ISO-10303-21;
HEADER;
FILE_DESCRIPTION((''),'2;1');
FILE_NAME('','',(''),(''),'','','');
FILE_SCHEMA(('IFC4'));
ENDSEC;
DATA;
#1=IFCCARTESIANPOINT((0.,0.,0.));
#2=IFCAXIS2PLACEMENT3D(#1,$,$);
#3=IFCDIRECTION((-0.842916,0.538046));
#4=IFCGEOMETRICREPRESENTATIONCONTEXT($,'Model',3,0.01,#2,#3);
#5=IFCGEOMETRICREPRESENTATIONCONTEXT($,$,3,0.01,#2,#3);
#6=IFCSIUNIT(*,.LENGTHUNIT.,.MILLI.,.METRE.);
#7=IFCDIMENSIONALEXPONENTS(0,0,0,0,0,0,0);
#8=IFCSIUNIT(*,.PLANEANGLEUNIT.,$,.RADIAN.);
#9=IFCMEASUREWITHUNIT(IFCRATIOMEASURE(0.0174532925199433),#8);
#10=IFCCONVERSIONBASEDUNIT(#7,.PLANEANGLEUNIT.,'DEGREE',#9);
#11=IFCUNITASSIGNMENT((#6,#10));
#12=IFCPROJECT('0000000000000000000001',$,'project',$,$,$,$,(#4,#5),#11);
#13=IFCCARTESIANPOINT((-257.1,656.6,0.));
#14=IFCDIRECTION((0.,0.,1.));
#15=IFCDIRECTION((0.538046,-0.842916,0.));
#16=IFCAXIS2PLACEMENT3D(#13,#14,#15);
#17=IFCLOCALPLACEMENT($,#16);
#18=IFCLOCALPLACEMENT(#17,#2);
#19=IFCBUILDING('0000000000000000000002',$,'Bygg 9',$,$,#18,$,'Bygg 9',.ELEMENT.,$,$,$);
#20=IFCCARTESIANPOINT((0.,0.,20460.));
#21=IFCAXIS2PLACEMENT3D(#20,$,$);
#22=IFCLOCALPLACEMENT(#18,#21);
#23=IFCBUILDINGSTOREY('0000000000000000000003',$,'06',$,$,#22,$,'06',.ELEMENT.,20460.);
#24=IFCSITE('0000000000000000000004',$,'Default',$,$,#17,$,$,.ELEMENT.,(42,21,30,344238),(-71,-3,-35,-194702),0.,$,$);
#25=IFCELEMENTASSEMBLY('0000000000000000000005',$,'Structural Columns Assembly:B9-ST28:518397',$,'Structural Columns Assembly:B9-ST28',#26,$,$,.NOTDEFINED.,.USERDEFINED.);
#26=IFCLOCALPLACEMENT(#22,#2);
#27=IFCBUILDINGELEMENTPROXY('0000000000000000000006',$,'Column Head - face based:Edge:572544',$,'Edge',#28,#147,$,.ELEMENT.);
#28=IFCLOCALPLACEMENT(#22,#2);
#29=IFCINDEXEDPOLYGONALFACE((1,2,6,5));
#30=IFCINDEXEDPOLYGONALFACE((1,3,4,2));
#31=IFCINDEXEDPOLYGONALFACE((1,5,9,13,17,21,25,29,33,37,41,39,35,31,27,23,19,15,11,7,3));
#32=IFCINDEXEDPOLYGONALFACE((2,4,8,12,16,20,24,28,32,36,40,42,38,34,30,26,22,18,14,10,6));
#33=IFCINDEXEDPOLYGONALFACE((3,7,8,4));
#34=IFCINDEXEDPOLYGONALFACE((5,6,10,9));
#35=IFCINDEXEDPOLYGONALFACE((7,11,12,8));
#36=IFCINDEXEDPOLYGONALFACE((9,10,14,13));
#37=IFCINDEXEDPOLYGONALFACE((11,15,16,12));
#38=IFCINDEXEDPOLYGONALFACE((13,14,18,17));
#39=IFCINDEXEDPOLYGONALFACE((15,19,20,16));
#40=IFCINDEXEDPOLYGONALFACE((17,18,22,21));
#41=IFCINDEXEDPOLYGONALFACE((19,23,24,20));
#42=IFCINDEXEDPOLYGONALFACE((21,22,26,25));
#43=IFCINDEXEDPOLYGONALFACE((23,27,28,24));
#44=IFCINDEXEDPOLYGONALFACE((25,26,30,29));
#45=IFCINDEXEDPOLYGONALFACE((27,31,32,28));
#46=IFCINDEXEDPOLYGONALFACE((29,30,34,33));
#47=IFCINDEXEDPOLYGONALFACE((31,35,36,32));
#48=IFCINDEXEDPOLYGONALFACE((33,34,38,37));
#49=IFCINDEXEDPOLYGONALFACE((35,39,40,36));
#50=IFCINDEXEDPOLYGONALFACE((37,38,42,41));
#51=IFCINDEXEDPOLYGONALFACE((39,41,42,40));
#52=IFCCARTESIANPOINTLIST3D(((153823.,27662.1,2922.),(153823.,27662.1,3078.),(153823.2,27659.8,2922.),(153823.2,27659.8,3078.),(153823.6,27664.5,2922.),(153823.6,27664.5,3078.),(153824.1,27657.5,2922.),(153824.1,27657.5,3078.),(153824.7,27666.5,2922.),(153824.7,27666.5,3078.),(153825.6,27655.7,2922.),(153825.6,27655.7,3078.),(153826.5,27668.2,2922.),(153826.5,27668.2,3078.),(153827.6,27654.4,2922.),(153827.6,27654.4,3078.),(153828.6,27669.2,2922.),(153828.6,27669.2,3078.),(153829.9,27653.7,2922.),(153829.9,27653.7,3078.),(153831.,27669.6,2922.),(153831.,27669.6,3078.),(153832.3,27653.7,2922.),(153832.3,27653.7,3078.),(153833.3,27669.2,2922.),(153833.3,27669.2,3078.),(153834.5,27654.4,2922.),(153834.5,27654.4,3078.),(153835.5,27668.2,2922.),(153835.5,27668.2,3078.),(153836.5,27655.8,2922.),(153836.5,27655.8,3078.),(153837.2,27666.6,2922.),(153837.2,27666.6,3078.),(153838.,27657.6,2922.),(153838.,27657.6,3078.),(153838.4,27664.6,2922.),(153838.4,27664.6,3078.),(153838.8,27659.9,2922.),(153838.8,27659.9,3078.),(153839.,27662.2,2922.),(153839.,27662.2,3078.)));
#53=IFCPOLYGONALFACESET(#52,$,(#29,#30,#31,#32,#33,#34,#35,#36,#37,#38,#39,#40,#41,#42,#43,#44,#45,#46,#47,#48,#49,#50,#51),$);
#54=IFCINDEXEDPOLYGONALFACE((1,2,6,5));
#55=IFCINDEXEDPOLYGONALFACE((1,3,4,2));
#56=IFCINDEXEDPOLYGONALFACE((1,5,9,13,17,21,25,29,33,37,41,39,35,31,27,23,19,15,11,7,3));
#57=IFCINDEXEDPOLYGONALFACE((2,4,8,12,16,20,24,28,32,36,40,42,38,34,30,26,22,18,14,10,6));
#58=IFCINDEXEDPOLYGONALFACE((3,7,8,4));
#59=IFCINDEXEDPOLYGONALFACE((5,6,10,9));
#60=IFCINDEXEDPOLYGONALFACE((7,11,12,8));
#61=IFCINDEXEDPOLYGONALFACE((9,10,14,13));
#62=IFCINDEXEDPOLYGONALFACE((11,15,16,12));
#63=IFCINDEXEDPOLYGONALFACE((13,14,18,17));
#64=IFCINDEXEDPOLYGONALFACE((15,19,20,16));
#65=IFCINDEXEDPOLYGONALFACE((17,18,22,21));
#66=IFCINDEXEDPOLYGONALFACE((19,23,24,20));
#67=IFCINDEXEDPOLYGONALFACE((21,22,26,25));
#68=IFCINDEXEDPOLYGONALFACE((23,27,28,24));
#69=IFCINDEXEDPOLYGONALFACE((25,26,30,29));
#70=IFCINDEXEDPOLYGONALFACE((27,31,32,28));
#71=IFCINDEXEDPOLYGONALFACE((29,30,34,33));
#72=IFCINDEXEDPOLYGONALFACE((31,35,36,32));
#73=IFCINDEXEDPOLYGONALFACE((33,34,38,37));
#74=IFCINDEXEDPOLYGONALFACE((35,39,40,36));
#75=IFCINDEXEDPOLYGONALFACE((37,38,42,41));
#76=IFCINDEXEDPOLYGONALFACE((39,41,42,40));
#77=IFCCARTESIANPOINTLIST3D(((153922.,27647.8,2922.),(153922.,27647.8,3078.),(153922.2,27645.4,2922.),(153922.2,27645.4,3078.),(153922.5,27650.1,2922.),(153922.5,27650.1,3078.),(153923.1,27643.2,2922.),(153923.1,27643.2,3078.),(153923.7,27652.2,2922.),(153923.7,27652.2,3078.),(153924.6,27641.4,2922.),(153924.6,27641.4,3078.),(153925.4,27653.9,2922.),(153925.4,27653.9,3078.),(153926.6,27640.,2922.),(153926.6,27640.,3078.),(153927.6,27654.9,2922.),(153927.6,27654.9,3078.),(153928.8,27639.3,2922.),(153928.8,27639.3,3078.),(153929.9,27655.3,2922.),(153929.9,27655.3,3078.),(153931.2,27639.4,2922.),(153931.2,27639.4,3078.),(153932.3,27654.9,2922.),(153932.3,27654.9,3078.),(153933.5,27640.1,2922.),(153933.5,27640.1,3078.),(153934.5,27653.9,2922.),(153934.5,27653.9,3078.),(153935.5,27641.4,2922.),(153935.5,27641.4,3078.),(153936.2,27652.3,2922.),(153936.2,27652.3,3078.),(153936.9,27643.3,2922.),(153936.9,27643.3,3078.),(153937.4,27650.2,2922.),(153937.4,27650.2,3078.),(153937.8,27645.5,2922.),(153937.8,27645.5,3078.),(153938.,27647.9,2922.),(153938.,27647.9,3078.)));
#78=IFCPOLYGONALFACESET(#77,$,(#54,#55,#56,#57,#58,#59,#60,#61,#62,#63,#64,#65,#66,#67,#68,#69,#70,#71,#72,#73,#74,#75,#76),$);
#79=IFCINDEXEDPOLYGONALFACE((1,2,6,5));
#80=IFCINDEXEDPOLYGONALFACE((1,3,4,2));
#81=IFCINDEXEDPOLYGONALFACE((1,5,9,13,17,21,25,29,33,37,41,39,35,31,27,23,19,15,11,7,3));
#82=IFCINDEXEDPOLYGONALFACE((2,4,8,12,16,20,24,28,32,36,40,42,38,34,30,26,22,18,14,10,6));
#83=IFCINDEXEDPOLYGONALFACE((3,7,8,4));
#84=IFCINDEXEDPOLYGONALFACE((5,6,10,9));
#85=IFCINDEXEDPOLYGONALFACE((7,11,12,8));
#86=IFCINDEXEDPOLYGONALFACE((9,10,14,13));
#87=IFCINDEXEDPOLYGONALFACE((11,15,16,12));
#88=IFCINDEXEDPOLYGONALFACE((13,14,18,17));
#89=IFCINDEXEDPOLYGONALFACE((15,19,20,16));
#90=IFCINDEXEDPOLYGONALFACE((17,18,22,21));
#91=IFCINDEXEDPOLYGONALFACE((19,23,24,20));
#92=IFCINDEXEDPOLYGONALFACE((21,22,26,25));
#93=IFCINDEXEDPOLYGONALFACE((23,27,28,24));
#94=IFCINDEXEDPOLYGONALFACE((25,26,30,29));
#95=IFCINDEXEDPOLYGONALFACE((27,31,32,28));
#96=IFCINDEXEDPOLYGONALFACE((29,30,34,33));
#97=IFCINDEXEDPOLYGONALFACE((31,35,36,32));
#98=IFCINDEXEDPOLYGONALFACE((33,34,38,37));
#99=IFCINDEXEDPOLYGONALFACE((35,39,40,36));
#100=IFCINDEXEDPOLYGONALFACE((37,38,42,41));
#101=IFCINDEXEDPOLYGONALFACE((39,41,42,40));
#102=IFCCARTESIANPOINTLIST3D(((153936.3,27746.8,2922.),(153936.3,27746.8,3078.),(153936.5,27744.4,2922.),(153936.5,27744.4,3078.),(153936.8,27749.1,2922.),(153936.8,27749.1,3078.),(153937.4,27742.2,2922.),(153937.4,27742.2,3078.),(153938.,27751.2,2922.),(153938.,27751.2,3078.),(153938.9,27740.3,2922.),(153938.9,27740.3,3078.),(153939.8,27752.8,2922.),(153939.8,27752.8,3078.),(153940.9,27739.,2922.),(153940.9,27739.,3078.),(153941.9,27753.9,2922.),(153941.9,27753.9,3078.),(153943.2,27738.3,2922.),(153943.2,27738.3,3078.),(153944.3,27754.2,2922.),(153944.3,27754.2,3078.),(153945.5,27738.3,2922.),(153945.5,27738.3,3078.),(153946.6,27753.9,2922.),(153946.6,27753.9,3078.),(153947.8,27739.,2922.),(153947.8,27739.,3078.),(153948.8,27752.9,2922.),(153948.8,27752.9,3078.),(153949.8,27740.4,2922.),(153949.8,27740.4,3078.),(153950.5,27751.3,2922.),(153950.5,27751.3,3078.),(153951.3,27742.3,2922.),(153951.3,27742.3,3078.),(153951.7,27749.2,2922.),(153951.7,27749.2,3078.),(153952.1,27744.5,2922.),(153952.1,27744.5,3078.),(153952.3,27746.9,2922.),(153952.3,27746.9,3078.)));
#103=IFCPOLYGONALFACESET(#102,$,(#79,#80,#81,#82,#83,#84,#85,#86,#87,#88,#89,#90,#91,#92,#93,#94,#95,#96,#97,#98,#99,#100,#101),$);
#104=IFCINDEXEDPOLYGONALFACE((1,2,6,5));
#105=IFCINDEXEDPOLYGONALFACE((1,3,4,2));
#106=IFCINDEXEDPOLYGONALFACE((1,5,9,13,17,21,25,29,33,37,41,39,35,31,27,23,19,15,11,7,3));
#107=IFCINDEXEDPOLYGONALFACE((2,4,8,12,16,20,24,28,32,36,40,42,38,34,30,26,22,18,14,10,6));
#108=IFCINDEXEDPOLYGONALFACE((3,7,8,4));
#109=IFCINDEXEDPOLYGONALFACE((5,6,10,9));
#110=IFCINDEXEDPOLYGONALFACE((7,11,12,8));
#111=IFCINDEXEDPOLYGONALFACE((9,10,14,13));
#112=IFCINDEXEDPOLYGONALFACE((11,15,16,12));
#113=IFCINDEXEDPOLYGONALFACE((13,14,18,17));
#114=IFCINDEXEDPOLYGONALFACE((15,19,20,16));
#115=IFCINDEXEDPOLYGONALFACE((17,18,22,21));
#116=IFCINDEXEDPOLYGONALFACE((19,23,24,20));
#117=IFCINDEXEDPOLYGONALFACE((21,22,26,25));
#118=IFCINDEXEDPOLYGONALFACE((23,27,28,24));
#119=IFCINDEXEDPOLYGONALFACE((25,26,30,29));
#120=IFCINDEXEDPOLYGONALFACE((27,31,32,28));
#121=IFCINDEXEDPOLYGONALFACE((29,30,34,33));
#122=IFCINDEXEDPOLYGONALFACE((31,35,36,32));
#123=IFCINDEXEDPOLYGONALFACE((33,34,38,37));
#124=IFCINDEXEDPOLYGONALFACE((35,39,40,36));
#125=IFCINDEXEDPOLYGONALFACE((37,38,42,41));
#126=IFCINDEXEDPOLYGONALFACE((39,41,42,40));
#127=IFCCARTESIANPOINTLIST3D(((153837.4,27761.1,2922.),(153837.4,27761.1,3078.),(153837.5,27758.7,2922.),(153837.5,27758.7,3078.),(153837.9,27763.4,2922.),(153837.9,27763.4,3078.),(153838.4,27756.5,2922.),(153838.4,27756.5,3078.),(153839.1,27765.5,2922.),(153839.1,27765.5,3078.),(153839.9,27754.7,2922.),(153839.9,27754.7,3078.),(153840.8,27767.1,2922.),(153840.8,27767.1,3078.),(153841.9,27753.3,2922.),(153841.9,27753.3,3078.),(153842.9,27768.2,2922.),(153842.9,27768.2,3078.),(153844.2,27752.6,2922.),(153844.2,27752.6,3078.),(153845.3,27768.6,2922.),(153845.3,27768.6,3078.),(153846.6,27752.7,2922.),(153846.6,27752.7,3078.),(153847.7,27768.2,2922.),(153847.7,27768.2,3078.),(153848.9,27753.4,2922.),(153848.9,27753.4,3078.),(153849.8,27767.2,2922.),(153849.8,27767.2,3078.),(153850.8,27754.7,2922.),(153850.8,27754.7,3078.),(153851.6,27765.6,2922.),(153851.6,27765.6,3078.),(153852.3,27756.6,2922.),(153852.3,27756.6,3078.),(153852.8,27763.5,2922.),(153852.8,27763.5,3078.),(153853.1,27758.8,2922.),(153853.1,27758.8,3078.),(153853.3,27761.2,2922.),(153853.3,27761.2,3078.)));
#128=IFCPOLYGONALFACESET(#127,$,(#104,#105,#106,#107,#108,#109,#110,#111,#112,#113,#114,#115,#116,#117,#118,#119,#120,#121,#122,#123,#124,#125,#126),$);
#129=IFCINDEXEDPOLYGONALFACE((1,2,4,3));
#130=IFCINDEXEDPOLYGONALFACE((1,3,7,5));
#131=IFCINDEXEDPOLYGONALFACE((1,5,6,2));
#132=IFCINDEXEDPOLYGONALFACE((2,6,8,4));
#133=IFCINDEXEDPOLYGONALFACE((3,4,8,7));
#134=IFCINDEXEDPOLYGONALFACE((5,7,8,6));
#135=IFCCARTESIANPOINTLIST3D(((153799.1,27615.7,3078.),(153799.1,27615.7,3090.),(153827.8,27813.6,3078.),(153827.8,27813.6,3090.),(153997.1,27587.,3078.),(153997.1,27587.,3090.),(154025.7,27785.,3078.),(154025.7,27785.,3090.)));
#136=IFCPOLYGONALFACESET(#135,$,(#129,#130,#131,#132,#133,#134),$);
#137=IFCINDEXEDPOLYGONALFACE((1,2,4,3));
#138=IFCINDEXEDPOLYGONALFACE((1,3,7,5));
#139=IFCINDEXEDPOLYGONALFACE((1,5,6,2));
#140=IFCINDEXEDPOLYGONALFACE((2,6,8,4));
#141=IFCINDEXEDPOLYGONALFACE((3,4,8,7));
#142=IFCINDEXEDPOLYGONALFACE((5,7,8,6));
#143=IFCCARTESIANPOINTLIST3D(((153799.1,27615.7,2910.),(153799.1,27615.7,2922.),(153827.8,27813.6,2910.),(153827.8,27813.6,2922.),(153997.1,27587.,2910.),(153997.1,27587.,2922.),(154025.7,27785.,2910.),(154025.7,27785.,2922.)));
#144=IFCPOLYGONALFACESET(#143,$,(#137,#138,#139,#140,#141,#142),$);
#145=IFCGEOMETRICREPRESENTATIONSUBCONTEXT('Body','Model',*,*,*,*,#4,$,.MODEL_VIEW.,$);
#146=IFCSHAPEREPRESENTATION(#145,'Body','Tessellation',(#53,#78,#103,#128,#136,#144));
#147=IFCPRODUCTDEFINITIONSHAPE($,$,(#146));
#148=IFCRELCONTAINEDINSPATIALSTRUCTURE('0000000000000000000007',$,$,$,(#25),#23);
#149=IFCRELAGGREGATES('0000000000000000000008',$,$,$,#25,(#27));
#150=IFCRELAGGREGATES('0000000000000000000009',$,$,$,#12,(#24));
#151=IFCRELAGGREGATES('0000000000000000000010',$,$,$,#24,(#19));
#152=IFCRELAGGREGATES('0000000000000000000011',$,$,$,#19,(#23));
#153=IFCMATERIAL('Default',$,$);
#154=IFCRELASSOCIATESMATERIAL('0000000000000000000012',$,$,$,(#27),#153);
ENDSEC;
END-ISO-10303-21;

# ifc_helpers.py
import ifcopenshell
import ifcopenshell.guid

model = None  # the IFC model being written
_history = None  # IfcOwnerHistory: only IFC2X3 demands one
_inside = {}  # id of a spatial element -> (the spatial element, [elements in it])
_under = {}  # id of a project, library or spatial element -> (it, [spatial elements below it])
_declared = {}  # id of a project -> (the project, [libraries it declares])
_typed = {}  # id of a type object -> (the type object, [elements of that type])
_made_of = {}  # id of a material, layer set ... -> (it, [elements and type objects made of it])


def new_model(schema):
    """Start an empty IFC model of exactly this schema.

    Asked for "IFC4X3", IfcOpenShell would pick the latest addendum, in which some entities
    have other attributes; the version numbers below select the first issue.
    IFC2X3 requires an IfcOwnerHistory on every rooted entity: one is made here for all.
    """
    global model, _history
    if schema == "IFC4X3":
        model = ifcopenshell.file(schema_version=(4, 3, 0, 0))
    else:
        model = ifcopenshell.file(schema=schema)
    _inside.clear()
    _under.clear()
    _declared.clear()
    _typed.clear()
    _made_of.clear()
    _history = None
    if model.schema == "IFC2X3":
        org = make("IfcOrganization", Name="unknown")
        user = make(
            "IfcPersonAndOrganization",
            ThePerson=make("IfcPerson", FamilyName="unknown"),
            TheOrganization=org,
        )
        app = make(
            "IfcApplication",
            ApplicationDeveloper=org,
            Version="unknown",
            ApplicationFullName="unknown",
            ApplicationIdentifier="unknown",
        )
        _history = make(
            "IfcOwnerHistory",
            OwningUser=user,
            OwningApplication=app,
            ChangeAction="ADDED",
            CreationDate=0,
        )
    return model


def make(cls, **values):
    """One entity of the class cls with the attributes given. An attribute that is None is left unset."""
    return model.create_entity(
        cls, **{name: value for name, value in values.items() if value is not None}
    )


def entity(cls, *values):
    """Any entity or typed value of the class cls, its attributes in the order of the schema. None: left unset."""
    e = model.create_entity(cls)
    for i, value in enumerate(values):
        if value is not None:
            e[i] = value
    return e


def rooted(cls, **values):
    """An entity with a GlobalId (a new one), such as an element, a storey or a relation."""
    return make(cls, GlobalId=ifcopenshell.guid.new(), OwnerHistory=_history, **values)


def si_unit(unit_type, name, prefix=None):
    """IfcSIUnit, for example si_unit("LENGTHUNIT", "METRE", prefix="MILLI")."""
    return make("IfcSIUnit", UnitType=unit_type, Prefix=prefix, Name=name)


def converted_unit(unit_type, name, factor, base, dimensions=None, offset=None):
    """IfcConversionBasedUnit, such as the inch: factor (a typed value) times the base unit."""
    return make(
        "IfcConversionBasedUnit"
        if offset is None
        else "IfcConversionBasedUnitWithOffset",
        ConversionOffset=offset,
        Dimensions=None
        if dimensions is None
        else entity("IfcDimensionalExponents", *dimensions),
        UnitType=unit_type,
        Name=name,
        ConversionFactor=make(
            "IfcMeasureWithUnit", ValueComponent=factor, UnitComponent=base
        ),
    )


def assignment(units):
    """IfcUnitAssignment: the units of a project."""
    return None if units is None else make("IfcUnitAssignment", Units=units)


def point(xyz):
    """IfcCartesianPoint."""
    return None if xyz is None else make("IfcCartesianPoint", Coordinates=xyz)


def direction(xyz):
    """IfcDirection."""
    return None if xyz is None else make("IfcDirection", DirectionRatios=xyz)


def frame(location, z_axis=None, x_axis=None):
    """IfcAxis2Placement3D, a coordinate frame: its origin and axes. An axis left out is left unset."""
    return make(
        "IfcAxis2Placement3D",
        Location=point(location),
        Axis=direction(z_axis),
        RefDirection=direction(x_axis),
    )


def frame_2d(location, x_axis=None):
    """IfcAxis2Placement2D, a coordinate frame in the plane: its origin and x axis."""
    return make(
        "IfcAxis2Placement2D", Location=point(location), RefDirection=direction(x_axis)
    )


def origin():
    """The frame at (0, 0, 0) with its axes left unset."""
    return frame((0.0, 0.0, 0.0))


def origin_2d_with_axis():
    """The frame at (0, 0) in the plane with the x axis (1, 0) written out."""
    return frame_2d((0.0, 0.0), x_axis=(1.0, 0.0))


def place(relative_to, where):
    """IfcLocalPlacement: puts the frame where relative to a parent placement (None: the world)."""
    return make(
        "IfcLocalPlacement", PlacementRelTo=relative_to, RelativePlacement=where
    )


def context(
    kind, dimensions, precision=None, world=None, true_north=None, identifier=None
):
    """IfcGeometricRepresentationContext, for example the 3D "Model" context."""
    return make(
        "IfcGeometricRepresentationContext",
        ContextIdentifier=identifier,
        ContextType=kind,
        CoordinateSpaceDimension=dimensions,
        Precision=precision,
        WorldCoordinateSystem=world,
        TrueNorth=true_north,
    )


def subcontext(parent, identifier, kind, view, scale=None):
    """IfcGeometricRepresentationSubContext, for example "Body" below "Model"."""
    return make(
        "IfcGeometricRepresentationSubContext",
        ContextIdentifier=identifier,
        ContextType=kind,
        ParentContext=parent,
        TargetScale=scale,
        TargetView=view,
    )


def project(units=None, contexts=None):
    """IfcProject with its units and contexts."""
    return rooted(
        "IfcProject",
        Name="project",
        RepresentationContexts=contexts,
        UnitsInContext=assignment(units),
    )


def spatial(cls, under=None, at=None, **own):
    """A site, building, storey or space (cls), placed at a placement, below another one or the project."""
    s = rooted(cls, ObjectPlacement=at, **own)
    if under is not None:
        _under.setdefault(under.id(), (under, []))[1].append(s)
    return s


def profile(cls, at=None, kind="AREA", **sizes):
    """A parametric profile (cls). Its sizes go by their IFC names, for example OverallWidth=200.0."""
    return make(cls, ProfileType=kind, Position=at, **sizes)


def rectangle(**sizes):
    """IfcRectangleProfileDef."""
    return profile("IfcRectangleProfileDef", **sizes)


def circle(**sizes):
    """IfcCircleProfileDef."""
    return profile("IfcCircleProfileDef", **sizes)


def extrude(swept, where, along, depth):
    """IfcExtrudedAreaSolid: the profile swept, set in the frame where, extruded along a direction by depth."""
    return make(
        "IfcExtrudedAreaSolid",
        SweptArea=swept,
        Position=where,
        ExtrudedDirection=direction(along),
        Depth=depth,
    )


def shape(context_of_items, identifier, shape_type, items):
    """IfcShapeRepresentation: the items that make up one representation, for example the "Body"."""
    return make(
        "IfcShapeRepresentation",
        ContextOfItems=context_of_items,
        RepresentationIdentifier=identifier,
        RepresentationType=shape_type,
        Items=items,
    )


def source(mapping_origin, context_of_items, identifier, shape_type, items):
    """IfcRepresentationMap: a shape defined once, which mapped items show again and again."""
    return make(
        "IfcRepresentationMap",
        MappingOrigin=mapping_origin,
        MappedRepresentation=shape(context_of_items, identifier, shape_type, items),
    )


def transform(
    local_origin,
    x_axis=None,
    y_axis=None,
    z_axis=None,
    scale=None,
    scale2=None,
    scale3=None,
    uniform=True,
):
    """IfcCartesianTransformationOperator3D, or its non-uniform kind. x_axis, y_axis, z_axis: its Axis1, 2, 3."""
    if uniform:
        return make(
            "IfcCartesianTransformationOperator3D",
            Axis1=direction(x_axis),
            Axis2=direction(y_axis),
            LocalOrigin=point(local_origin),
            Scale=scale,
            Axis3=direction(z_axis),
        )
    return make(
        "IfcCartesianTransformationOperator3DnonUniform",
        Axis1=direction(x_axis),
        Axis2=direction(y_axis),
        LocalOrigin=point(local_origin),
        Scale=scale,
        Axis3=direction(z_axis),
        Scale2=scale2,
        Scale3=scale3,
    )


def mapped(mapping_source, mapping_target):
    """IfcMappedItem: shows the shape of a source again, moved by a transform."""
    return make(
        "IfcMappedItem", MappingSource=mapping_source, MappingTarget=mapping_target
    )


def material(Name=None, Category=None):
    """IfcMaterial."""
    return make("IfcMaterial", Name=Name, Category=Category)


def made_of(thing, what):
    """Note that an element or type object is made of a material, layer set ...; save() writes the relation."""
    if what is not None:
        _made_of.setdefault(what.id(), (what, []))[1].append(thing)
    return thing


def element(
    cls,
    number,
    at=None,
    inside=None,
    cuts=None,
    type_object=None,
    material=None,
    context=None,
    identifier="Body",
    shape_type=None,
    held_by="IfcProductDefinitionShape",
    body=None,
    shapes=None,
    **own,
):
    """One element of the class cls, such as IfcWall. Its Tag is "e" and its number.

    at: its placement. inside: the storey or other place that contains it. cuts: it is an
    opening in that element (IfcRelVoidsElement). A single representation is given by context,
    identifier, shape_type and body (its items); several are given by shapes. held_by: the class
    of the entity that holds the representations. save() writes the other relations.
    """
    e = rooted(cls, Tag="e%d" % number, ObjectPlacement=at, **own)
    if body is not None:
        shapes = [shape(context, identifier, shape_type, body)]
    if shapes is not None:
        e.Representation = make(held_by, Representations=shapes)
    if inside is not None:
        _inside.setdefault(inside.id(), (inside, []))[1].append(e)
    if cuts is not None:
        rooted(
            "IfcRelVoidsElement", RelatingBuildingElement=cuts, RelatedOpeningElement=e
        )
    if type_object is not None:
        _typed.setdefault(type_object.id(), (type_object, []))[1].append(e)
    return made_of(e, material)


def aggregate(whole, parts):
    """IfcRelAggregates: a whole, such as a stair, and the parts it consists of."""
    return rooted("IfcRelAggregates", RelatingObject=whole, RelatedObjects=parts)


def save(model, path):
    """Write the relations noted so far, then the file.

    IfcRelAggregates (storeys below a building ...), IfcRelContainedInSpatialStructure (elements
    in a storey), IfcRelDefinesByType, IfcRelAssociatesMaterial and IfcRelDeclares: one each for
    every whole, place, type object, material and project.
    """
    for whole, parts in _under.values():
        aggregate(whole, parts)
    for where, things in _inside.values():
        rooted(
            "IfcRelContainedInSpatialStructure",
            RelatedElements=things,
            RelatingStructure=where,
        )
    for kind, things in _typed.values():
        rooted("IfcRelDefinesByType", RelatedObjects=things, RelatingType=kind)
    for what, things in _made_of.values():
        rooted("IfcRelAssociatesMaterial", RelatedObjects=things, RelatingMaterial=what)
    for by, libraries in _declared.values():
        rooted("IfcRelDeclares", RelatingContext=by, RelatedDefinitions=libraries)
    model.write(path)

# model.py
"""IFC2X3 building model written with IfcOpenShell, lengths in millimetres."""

from ifc_helpers import new_model, entity, si_unit, converted_unit, direction, frame, frame_2d, origin, origin_2d_with_axis, place, context, subcontext, project, spatial, rectangle, circle, extrude, source, transform, mapped, material, element, aggregate, save


model = new_model("IFC2X3")

# Units and contexts
model_context = context("Model", 3, precision=0.01, world=origin(), true_north=direction((-0.842916, 0.538046)))
context_of_model = context(None, 3, precision=0.01, world=origin(), true_north=direction((-0.842916, 0.538046)))
body_context = subcontext(model_context, "Body", "Model", "MODEL_VIEW")
ifc_project = project(units=[si_unit("LENGTHUNIT", "METRE", prefix="MILLI"), converted_unit("PLANEANGLEUNIT", "DEGREE", entity("IfcRatioMeasure", 0.0174532925199433), si_unit("PLANEANGLEUNIT", "RADIAN"), dimensions=[0, 0, 0, 0, 0, 0, 0])], contexts=[model_context, context_of_model])

# Site, building, storey
site_placement = place(None, frame((-257.1, 656.6, 0.0), z_axis=(0.0, 0.0, 1.0), x_axis=(0.538046, -0.842916, 0.0)))
site = spatial("IfcSite", under=ifc_project, at=site_placement, Name="Default", CompositionType="ELEMENT", RefLatitude=(42, 21, 30, 344238), RefLongitude=(-71, -3, -35, -194702), RefElevation=0.0)
building_placement = place(site_placement, origin())
building = spatial("IfcBuilding", under=site, at=building_placement, Name="Bygg 9", LongName="Bygg 9", CompositionType="ELEMENT")
storey_placement = place(building_placement, frame((0.0, 0.0, 20460.0)))
storey = spatial("IfcBuildingStorey", under=building, at=storey_placement, Name="06", LongName="06", CompositionType="ELEMENT", Elevation=20460.0)

# Element assembly
assembly_1_placement = place(storey_placement, origin())
assembly_1 = element("IfcElementAssembly", 1, at=assembly_1_placement, inside=storey, Name="Structural Columns Assembly:B9-ST28:518397", ObjectType="Structural Columns Assembly:B9-ST28", AssemblyPlace="NOTDEFINED", PredefinedType="USERDEFINED")

# Shared definitions
ifc_material_1 = material(Name="Default")

# Building element proxy
shared_shape_1 = source(origin(), body_context, "Body", "SweptSolid", [
    extrude(circle(Radius=8.0, at=frame_2d((0.0, 0.0), x_axis=(1.0, 0.0))), frame((50.0, -75.0, 12.0)), (0.0, 0.0, 1.0), 156.0),
    extrude(circle(Radius=8.0, at=frame_2d((0.0, 0.0), x_axis=(1.0, 0.0))), frame((50.0, 25.0, 12.0)), (0.0, 0.0, 1.0), 156.0),
    extrude(circle(Radius=8.0, at=frame_2d((0.0, 0.0), x_axis=(1.0, 0.0))), frame((-50.0, 25.0, 12.0)), (0.0, 0.0, 1.0), 156.0),
    extrude(circle(Radius=8.0, at=frame_2d((0.0, 0.0), x_axis=(1.0, 0.0))), frame((-50.0, -75.0, 12.0)), (0.0, 0.0, 1.0), 156.0),
    extrude(rectangle(XDim=200.0, YDim=200.0, at=origin_2d_with_axis()), frame((0.0, 0.0, 168.0), z_axis=(0.0, 0.0, 1.0), x_axis=(-1.0, 0.0, 0.0)), (0.0, 0.0, 1.0), 12.0),
    extrude(rectangle(XDim=200.0, YDim=200.0, at=origin_2d_with_axis()), frame((0.0, 0.0, 0.0), z_axis=(0.0, 0.0, 1.0), x_axis=(0.0, 1.0, 0.0)), (0.0, 0.0, 1.0), 12.0),
])
proxy_1_placement = place(assembly_1_placement, frame((153912.4, 27700.3, 2910.0), z_axis=(0.0, 0.0, 1.0), x_axis=(-0.143216, -0.989691, 0.0)))
proxy_1 = element("IfcBuildingElementProxy", 2, at=proxy_1_placement, material=ifc_material_1, Name="Column Head - face based:Edge:572544", ObjectType="Edge", CompositionType="ELEMENT", context=body_context, shape_type="MappedRepresentation", body=[
    mapped(shared_shape_1, transform((0.0, 0.0, 0.0), scale=1.0)),
])
aggregate(assembly_1, [proxy_1])

save(model, "model.ifc")
